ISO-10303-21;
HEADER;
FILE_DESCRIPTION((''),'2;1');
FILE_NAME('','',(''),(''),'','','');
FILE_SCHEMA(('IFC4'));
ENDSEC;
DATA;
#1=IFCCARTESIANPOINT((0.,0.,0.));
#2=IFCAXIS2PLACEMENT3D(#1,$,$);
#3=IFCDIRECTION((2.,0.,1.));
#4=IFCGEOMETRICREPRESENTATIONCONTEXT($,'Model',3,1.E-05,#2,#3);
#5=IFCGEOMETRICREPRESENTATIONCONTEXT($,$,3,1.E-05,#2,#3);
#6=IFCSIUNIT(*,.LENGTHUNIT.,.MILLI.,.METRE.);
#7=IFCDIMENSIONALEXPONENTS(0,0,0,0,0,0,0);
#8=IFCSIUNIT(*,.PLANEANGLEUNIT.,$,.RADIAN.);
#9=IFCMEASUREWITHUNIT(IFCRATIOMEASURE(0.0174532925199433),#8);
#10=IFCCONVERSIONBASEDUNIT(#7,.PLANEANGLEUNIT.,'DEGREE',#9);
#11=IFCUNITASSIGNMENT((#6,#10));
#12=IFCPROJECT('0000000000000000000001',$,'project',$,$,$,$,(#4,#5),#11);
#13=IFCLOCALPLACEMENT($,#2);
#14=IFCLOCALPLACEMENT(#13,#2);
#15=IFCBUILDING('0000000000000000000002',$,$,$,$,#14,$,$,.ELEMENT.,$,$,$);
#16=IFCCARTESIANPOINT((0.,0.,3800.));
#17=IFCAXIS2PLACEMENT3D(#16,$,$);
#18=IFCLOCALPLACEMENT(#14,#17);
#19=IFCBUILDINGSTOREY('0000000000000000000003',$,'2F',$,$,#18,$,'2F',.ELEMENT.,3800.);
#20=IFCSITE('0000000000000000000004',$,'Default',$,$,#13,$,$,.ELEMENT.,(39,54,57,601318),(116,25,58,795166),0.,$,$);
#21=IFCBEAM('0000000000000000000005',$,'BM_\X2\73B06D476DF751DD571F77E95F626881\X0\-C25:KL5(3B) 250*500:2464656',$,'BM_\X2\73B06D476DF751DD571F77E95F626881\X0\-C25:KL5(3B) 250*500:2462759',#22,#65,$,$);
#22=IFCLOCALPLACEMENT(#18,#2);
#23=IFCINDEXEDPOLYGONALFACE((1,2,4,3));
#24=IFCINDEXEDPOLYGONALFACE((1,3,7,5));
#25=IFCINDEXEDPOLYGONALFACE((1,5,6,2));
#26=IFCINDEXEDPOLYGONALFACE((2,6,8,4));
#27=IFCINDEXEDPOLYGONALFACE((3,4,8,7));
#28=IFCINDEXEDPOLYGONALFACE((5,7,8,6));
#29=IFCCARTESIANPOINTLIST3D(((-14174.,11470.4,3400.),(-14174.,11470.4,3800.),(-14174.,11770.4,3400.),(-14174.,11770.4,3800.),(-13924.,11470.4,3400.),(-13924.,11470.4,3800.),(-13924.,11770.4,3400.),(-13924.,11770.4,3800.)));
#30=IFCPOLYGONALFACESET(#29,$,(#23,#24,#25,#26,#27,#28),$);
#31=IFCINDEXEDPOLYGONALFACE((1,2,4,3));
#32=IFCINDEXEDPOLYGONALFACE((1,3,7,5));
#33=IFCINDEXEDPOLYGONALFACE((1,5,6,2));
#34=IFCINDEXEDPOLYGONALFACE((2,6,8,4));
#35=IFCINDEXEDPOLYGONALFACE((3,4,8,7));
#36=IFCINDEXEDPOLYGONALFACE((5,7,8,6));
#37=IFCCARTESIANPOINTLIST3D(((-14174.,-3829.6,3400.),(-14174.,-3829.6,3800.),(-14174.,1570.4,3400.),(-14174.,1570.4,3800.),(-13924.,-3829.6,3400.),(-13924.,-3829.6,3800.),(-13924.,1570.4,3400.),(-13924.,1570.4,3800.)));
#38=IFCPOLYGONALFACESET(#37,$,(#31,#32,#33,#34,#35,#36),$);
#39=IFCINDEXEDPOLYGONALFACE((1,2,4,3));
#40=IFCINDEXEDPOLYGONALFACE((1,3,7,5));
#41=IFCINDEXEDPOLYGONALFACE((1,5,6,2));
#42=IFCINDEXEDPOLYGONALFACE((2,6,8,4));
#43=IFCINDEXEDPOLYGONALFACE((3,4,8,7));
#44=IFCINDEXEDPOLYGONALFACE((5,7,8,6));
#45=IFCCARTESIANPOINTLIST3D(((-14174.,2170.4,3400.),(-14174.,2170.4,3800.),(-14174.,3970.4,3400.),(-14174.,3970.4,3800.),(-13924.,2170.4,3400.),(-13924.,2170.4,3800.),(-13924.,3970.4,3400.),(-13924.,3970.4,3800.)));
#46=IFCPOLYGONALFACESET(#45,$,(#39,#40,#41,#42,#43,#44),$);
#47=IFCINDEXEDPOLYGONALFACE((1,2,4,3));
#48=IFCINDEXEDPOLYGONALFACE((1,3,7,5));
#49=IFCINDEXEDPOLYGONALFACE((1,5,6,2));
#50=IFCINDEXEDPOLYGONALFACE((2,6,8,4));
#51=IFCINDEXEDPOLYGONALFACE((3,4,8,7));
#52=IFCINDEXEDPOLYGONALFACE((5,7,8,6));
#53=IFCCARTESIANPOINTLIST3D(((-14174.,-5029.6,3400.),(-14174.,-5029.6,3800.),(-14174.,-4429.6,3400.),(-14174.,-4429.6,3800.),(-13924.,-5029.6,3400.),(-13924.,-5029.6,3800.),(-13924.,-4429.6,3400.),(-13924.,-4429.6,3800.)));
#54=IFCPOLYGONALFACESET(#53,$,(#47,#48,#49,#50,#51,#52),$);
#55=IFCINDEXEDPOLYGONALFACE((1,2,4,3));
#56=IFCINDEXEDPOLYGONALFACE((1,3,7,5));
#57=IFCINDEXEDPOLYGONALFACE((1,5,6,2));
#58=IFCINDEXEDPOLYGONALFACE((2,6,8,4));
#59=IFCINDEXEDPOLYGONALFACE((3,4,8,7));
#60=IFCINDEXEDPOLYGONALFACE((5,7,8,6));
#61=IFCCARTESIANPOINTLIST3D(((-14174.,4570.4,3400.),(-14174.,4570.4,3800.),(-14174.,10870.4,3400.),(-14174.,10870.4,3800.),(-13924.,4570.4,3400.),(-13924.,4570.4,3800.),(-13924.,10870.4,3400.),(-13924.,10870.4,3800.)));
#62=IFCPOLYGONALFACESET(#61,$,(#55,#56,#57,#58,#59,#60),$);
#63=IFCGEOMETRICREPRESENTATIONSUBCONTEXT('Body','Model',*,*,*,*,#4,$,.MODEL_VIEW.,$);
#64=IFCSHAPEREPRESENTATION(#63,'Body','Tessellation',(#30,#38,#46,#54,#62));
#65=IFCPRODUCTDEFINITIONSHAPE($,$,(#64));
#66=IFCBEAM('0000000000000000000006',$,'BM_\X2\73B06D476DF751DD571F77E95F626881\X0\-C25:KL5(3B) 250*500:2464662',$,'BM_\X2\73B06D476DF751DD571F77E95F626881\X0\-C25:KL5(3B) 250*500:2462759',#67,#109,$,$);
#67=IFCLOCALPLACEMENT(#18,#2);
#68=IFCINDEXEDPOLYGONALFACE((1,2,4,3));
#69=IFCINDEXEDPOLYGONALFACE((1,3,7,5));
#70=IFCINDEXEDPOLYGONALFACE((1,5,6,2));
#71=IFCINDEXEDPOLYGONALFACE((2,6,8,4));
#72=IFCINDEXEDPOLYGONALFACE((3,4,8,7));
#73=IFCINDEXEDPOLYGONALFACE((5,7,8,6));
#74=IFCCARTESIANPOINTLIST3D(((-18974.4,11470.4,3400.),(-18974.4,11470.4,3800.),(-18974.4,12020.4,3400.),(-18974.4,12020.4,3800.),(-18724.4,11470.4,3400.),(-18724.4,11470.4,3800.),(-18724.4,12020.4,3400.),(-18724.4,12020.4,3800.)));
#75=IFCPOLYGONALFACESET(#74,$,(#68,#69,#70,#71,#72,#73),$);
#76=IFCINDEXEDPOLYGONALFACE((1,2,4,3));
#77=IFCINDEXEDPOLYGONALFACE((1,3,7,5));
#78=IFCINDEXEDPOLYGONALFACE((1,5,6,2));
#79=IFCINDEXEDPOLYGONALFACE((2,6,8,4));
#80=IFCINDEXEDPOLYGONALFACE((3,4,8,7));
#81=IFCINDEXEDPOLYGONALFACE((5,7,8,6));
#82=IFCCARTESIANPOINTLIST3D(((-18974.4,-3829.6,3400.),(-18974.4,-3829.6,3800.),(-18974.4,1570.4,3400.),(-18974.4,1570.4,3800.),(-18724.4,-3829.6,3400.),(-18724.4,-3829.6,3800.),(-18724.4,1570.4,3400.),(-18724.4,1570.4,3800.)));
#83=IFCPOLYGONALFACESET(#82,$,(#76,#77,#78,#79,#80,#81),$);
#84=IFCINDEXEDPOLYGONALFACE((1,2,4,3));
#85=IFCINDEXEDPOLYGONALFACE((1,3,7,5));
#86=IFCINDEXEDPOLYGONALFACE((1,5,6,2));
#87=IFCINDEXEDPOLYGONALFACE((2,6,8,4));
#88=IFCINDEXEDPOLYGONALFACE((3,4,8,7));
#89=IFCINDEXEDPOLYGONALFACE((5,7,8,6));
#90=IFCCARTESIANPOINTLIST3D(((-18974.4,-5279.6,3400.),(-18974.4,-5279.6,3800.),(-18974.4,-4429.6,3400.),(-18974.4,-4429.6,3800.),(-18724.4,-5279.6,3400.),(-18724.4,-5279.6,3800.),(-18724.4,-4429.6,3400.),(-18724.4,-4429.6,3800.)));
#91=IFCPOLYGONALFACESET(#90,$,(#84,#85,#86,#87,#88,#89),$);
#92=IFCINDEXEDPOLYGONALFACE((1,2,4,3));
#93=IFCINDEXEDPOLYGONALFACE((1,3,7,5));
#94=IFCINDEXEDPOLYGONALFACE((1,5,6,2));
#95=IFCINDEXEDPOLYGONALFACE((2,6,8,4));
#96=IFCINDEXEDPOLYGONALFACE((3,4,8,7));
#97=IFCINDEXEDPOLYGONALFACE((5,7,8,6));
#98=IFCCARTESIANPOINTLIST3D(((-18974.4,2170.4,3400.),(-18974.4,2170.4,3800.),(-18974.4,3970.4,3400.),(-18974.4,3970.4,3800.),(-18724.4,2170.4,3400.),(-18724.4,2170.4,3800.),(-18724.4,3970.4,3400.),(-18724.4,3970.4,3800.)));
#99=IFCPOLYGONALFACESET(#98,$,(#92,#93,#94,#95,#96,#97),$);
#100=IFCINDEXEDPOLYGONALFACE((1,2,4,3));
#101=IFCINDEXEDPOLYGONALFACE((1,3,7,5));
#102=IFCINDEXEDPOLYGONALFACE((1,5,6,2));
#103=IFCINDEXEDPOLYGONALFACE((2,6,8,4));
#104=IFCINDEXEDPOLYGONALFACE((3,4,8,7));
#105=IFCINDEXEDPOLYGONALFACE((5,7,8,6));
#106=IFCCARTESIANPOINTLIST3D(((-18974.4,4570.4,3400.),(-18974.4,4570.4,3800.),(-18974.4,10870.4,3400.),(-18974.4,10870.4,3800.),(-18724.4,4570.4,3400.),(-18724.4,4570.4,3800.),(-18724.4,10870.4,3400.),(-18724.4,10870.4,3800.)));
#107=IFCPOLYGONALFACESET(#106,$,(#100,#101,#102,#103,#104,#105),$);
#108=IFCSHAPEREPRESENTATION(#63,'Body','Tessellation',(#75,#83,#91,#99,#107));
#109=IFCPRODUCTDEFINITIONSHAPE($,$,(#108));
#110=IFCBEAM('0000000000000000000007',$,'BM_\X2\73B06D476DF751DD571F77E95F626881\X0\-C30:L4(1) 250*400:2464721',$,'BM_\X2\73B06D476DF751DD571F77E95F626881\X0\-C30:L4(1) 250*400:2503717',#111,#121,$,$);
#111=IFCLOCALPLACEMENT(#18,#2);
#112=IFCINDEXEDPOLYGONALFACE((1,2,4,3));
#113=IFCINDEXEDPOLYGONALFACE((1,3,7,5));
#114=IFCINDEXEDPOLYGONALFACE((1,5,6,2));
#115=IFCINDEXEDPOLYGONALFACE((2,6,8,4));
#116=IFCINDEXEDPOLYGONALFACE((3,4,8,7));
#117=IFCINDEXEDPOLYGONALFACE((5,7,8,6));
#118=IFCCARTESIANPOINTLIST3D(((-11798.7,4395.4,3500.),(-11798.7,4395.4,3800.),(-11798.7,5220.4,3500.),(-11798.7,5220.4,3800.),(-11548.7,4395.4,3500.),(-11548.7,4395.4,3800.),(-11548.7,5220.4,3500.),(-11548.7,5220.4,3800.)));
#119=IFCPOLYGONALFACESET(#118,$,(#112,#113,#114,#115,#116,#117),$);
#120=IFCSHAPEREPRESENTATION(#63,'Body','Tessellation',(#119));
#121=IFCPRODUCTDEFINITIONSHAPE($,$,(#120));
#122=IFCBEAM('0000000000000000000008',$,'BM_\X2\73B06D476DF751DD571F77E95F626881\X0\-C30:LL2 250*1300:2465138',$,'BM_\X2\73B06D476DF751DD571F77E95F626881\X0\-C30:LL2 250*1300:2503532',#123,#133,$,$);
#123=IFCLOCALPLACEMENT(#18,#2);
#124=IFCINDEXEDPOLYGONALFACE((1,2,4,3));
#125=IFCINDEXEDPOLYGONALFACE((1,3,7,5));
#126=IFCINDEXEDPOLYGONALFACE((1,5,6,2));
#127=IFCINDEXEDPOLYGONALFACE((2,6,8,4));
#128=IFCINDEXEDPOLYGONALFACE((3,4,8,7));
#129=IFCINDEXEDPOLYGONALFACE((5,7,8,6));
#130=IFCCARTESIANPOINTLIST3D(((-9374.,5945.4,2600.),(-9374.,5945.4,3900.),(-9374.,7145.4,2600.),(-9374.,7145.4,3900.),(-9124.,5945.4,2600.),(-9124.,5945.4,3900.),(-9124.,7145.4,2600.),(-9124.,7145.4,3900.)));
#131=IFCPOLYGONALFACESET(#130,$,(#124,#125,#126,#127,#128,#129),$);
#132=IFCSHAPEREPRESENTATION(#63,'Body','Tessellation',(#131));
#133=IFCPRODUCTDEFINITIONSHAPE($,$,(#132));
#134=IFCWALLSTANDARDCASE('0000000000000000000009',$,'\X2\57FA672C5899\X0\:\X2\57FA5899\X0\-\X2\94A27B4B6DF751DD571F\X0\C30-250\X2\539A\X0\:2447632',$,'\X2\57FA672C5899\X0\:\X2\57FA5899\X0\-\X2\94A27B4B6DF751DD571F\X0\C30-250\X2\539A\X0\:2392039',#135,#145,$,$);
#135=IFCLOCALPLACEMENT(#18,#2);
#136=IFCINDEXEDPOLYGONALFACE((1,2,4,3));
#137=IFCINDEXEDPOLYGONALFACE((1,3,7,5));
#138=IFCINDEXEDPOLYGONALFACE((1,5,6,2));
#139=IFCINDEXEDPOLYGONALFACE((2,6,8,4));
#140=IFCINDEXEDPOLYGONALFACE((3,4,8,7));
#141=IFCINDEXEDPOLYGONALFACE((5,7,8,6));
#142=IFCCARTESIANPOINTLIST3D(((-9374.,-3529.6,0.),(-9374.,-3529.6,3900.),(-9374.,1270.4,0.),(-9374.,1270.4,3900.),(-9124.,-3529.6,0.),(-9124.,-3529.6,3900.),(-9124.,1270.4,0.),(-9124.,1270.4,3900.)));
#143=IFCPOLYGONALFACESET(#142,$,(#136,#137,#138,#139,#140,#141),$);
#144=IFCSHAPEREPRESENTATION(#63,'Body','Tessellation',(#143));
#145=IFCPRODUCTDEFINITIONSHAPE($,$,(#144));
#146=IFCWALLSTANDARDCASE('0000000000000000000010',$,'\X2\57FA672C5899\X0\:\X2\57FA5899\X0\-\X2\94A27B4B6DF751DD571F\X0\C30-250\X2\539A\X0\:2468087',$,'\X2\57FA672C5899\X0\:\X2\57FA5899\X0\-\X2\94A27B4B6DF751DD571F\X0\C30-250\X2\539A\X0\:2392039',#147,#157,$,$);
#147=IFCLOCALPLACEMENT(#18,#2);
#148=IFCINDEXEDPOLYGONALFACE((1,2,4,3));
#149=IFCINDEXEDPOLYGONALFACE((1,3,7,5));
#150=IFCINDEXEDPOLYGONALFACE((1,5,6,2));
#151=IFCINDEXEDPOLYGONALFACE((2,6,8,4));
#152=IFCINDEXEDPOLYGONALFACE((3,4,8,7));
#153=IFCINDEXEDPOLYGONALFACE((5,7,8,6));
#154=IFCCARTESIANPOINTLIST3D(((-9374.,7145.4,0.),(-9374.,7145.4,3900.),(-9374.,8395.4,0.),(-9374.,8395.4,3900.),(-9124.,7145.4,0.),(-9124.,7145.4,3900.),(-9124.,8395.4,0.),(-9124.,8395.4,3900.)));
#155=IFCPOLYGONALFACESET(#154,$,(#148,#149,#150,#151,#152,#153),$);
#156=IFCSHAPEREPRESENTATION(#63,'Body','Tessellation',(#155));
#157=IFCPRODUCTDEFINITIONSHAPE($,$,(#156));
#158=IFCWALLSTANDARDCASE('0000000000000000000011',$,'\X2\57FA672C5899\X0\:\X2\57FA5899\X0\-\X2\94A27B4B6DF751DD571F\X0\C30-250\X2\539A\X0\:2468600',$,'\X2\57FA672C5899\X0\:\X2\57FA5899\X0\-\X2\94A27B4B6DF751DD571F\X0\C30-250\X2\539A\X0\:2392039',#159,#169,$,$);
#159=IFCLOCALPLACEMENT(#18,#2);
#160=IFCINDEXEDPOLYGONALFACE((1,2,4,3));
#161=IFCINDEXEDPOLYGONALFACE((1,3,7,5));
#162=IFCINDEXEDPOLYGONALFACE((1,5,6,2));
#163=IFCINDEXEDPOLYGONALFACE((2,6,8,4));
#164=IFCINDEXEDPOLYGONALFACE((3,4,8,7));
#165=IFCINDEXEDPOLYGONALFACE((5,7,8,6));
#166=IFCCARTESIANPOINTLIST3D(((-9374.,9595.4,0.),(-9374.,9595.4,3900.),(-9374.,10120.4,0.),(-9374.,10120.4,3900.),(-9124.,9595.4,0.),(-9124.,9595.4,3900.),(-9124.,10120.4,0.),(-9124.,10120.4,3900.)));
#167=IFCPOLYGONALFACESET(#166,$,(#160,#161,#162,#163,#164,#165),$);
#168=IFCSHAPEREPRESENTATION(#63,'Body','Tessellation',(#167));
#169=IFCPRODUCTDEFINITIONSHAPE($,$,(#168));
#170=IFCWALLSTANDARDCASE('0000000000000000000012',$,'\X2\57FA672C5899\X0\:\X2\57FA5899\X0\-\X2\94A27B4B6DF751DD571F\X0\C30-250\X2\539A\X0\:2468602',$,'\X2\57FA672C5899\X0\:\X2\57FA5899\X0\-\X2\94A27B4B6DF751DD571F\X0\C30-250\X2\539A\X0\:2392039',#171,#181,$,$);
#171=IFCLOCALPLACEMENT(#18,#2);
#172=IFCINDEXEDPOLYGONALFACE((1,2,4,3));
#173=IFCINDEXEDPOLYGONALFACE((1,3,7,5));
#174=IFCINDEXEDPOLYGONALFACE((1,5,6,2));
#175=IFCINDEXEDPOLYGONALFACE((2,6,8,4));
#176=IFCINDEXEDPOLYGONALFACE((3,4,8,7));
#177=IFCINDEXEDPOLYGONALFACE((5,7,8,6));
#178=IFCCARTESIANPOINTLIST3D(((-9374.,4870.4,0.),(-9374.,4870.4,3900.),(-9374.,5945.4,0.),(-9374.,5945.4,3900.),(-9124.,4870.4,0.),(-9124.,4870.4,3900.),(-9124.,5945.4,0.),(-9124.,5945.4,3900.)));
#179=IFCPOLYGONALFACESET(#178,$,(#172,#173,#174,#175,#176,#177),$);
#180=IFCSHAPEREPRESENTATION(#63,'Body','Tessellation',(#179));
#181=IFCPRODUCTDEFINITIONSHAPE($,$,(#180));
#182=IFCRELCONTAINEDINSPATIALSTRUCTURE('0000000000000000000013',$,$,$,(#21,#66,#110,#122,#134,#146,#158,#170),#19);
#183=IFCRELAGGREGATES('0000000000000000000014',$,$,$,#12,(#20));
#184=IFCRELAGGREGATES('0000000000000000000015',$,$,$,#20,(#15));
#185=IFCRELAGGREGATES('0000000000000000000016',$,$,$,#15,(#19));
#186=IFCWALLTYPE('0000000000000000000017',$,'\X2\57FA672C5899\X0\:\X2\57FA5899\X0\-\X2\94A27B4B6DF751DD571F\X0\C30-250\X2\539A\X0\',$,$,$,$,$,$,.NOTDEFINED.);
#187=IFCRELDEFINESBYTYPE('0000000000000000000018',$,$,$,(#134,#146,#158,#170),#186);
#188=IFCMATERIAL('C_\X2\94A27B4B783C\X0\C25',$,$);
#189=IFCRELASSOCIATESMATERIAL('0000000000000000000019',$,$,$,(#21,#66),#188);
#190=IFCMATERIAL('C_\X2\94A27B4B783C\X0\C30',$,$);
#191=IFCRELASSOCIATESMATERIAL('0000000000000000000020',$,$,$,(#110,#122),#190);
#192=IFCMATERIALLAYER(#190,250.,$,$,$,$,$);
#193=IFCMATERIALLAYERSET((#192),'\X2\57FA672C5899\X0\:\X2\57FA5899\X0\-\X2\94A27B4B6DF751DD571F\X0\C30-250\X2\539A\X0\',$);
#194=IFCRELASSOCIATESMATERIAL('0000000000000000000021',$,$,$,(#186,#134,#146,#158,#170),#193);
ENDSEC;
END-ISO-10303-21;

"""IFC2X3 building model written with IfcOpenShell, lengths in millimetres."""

from ifc_helpers import new_model, entity, si_unit, converted_unit, direction, frame, frame_2d, origin, place, context, subcontext, project, spatial, polyline, rectangle, extrude, clip, bounded_halfspace, material, layer, layer_set, layer_usage, type_object, element, save


model = new_model("IFC2X3")

# Units and contexts
model_context = context("Model", 3, precision=1e-05, world=origin(), true_north=direction((2.0, 0.0, 1.0)))
context_of_model = context(None, 3, precision=1e-05, world=origin(), true_north=direction((2.0, 0.0, 1.0)))
body_context = subcontext(model_context, "Body", "Model", "MODEL_VIEW")
ifc_project = project(units=[si_unit("LENGTHUNIT", "METRE", prefix="MILLI"), converted_unit("PLANEANGLEUNIT", "DEGREE", entity("IfcRatioMeasure", 0.0174532925199433), si_unit("PLANEANGLEUNIT", "RADIAN"), dimensions=[0, 0, 0, 0, 0, 0, 0])], contexts=[model_context, context_of_model])

# Site, building, storey
site_placement = place(None, origin())
site = spatial("IfcSite", under=ifc_project, at=site_placement, Name="Default", CompositionType="ELEMENT", RefLatitude=(39, 54, 57, 601318), RefLongitude=(116, 25, 58, 795166), RefElevation=0.0)
building_placement = place(site_placement, origin())
building = spatial("IfcBuilding", under=site, at=building_placement, CompositionType="ELEMENT")
storey_placement = place(building_placement, frame((0.0, 0.0, 3800.0)))
storey = spatial("IfcBuildingStorey", under=building, at=storey_placement, Name="2F", LongName="2F", CompositionType="ELEMENT", Elevation=3800.0)

# Beams
ifc_material_1 = material(Name="C_钢筋砼C25")
beam_1_placement = place(storey_placement, frame((-14049.0, 11895.4, 3900.0), z_axis=(0.0, 0.0, 1.0), x_axis=(0.0, -1.0, 0.0)))
element("IfcBeam", 1, at=beam_1_placement, inside=storey, material=ifc_material_1, Name="BM_现浇混凝土矩形梁-C25:KL5(3B) 250*500:2464656", ObjectType="BM_现浇混凝土矩形梁-C25:KL5(3B) 250*500:2462759", context=body_context, shape_type="SweptSolid", body=[
    extrude(rectangle(XDim=400.0, YDim=250.0, at=frame_2d((0.0, 0.0), x_axis=(1.0, 0.0))), frame((125.0, 0.0, -300.0), z_axis=(1.0, 0.0, 0.0), x_axis=(0.0, 0.0, 1.0)), (0.0, 0.0, 1.0), 300.0),
    extrude(rectangle(XDim=400.0, YDim=250.0, at=frame_2d((0.0, 0.0), x_axis=(1.0, 0.0))), frame((10325.0, 0.0, -300.0), z_axis=(1.0, 0.0, 0.0), x_axis=(0.0, 0.0, 1.0)), (0.0, 0.0, 1.0), 5400.0),
    extrude(rectangle(XDim=400.0, YDim=250.0, at=frame_2d((0.0, 0.0), x_axis=(1.0, 0.0))), frame((7925.0, 0.0, -300.0), z_axis=(1.0, 0.0, 0.0), x_axis=(0.0, 0.0, 1.0)), (0.0, 0.0, 1.0), 1800.0),
    extrude(rectangle(XDim=400.0, YDim=250.0, at=frame_2d((0.0, 0.0), x_axis=(1.0, 0.0))), frame((16325.0, 0.0, -300.0), z_axis=(1.0, 0.0, 0.0), x_axis=(0.0, 0.0, 1.0)), (0.0, 0.0, 1.0), 600.0),
    extrude(rectangle(XDim=400.0, YDim=250.0, at=frame_2d((0.0, 0.0), x_axis=(1.0, 0.0))), frame((1025.0, 0.0, -300.0), z_axis=(1.0, 0.0, 0.0), x_axis=(0.0, 0.0, 1.0)), (0.0, 0.0, 1.0), 6300.0),
])
beam_2_placement = place(storey_placement, frame((-18849.4, 11895.4, 3900.0), z_axis=(0.0, 0.0, 1.0), x_axis=(0.0, -1.0, 0.0)))
element("IfcBeam", 2, at=beam_2_placement, inside=storey, material=ifc_material_1, Name="BM_现浇混凝土矩形梁-C25:KL5(3B) 250*500:2464662", ObjectType="BM_现浇混凝土矩形梁-C25:KL5(3B) 250*500:2462759", context=body_context, shape_type="SweptSolid", body=[
    extrude(rectangle(XDim=400.0, YDim=250.0, at=frame_2d((0.0, 0.0), x_axis=(1.0, 0.0))), frame((-125.0, 0.0, -300.0), z_axis=(1.0, 0.0, 0.0), x_axis=(0.0, 0.0, 1.0)), (0.0, 0.0, 1.0), 550.0),
    extrude(rectangle(XDim=400.0, YDim=250.0, at=frame_2d((0.0, 0.0), x_axis=(1.0, 0.0))), frame((10325.0, 0.0, -300.0), z_axis=(1.0, 0.0, 0.0), x_axis=(0.0, 0.0, 1.0)), (0.0, 0.0, 1.0), 5400.0),
    extrude(rectangle(XDim=400.0, YDim=250.0, at=frame_2d((0.0, 0.0), x_axis=(1.0, 0.0))), frame((16325.0, 0.0, -300.0), z_axis=(1.0, 0.0, 0.0), x_axis=(0.0, 0.0, 1.0)), (0.0, 0.0, 1.0), 850.0),
    extrude(rectangle(XDim=400.0, YDim=250.0, at=frame_2d((0.0, 0.0), x_axis=(1.0, 0.0))), frame((7925.0, 0.0, -300.0), z_axis=(1.0, 0.0, 0.0), x_axis=(0.0, 0.0, 1.0)), (0.0, 0.0, 1.0), 1800.0),
    extrude(rectangle(XDim=400.0, YDim=250.0, at=frame_2d((0.0, 0.0), x_axis=(1.0, 0.0))), frame((1025.0, 0.0, -300.0), z_axis=(1.0, 0.0, 0.0), x_axis=(0.0, 0.0, 1.0)), (0.0, 0.0, 1.0), 6300.0),
])
ifc_material_2 = material(Name="C_钢筋砼C30")
beam_3_placement = place(storey_placement, frame((-11673.7, 4270.4, 3900.0), z_axis=(0.0, 0.0, 1.0), x_axis=(0.0, 1.0, 0.0)))
element("IfcBeam", 3, at=beam_3_placement, inside=storey, material=ifc_material_2, Name="BM_现浇混凝土矩形梁-C30:L4(1) 250*400:2464721", ObjectType="BM_现浇混凝土矩形梁-C30:L4(1) 250*400:2503717", context=body_context, shape_type="SweptSolid", body=[
    extrude(rectangle(XDim=300.0, YDim=250.0, at=frame_2d((0.0, 0.0), x_axis=(1.0, 0.0))), frame((125.0, 0.0, -250.0), z_axis=(1.0, 0.0, 0.0), x_axis=(0.0, 0.0, -1.0)), (0.0, 0.0, 1.0), 825.0),
])
beam_4_placement = place(storey_placement, frame((-9249.0, 7270.4, 3900.0), z_axis=(0.0, 0.0, 1.0), x_axis=(0.0, -1.0, 0.0)))
element("IfcBeam", 4, at=beam_4_placement, inside=storey, material=ifc_material_2, Name="BM_现浇混凝土矩形梁-C30:LL2 250*1300:2465138", ObjectType="BM_现浇混凝土矩形梁-C30:LL2 250*1300:2503532", context=body_context, shape_type="SweptSolid", body=[
    extrude(rectangle(XDim=1300.0, YDim=250.0, at=frame_2d((0.0, 0.0), x_axis=(1.0, 0.0))), frame((125.0, 0.0, -650.0), z_axis=(1.0, 0.0, 0.0), x_axis=(0.0, 0.0, -1.0)), (0.0, 0.0, 1.0), 1200.0),
])

# Walls
ifc_layer_1 = layer(ifc_material_2, 250.0)
ifc_layer_set_1 = layer_set([ifc_layer_1], Name="基本墙:基墙-钢筋混凝土C30-250厚")
wall_type_1 = type_object("IfcWallType", Name="基本墙:基墙-钢筋混凝土C30-250厚", PredefinedType="NOTDEFINED", material=ifc_layer_set_1)
ifc_layer_usage_1 = layer_usage(ifc_layer_set_1, "AXIS2", "NEGATIVE", 125.0)
wall_1_placement = place(storey_placement, frame((-9249.0, 1270.4, 0.0), z_axis=(0.0, 0.0, 1.0), x_axis=(0.0, -1.0, 0.0)))
element("IfcWallStandardCase", 5, at=wall_1_placement, inside=storey, type_object=wall_type_1, material=ifc_layer_usage_1, Name="基本墙:基墙-钢筋混凝土C30-250厚:2447632", ObjectType="基本墙:基墙-钢筋混凝土C30-250厚:2392039", context=body_context, shape_type="Clipping", body=[
    clip(clip(extrude(rectangle(XDim=4800.0, YDim=250.0, at=frame_2d((2400.0, 0.0), x_axis=(-1.0, 0.0))), origin(), (0.0, 0.0, 1.0), 3900.0), bounded_halfspace(frame((0.0, -125.0, 0.0), z_axis=(-1.0, 0.0, 0.0), x_axis=(0.0, 0.0, -1.0)), False, frame((0.0, -125.0, 0.0), z_axis=(-1.0, 0.0, 0.0), x_axis=(0.0, 0.0, -1.0)), polyline([(0.0, 0.0), (-3800.0, 0.0), (-3900.0, 0.0), (-3900.0, -250.0), (-3800.0, -250.0), (0.0, -250.0), (0.0, 0.0)]))), bounded_halfspace(frame((4800.0, -125.0, 3900.0), z_axis=(-1.0, 0.0, 0.0), x_axis=(0.0, 0.0, -1.0)), True, frame((4800.0, -125.0, 3900.0), z_axis=(-1.0, 0.0, 0.0), x_axis=(0.0, 0.0, -1.0)), polyline([(0.0, 0.0), (0.0, -250.0), (100.0, -250.0), (3900.0, -250.0), (3900.0, 0.0), (100.0, 0.0), (0.0, 0.0)]))),
])
ifc_layer_usage_2 = layer_usage(ifc_layer_set_1, "AXIS2", "NEGATIVE", 125.0)
wall_2_placement = place(storey_placement, frame((-9249.0, 8395.4, 0.0), z_axis=(0.0, 0.0, 1.0), x_axis=(0.0, -1.0, 0.0)))
element("IfcWallStandardCase", 6, at=wall_2_placement, inside=storey, type_object=wall_type_1, material=ifc_layer_usage_2, Name="基本墙:基墙-钢筋混凝土C30-250厚:2468087", ObjectType="基本墙:基墙-钢筋混凝土C30-250厚:2392039", context=body_context, shape_type="SweptSolid", body=[
    extrude(rectangle(XDim=1250.0, YDim=250.0, at=frame_2d((625.0, 0.0), x_axis=(-1.0, 0.0))), origin(), (0.0, 0.0, 1.0), 3900.0),
])
ifc_layer_usage_3 = layer_usage(ifc_layer_set_1, "AXIS2", "NEGATIVE", 125.0)
wall_3_placement = place(storey_placement, frame((-9249.0, 10120.4, 0.0), z_axis=(0.0, 0.0, 1.0), x_axis=(0.0, -1.0, 0.0)))
element("IfcWallStandardCase", 7, at=wall_3_placement, inside=storey, type_object=wall_type_1, material=ifc_layer_usage_3, Name="基本墙:基墙-钢筋混凝土C30-250厚:2468600", ObjectType="基本墙:基墙-钢筋混凝土C30-250厚:2392039", context=body_context, shape_type="SweptSolid", body=[
    extrude(rectangle(XDim=525.0, YDim=250.0, at=frame_2d((262.5, 0.0), x_axis=(-1.0, 0.0))), origin(), (0.0, 0.0, 1.0), 3900.0),
])
ifc_layer_usage_4 = layer_usage(ifc_layer_set_1, "AXIS2", "NEGATIVE", 125.0)
wall_4_placement = place(storey_placement, frame((-9249.0, 5945.4, 0.0), z_axis=(0.0, 0.0, 1.0), x_axis=(0.0, -1.0, 0.0)))
element("IfcWallStandardCase", 8, at=wall_4_placement, inside=storey, type_object=wall_type_1, material=ifc_layer_usage_4, Name="基本墙:基墙-钢筋混凝土C30-250厚:2468602", ObjectType="基本墙:基墙-钢筋混凝土C30-250厚:2392039", context=body_context, shape_type="Clipping", body=[
    clip(extrude(rectangle(XDim=1075.0, YDim=250.0, at=frame_2d((537.5, 0.0), x_axis=(-1.0, 0.0))), origin(), (0.0, 0.0, 1.0), 3900.0), bounded_halfspace(frame((1075.0, -125.0, 3900.0), z_axis=(-1.0, 0.0, 0.0), x_axis=(0.0, 0.0, -1.0)), True, frame((1075.0, -125.0, 3900.0), z_axis=(-1.0, 0.0, 0.0), x_axis=(0.0, 0.0, -1.0)), polyline([(0.0, 0.0), (0.0, -250.0), (100.0, -250.0), (3900.0, -250.0), (3900.0, 0.0), (100.0, 0.0), (0.0, 0.0)]))),
])

save(model, "model.ifc")
